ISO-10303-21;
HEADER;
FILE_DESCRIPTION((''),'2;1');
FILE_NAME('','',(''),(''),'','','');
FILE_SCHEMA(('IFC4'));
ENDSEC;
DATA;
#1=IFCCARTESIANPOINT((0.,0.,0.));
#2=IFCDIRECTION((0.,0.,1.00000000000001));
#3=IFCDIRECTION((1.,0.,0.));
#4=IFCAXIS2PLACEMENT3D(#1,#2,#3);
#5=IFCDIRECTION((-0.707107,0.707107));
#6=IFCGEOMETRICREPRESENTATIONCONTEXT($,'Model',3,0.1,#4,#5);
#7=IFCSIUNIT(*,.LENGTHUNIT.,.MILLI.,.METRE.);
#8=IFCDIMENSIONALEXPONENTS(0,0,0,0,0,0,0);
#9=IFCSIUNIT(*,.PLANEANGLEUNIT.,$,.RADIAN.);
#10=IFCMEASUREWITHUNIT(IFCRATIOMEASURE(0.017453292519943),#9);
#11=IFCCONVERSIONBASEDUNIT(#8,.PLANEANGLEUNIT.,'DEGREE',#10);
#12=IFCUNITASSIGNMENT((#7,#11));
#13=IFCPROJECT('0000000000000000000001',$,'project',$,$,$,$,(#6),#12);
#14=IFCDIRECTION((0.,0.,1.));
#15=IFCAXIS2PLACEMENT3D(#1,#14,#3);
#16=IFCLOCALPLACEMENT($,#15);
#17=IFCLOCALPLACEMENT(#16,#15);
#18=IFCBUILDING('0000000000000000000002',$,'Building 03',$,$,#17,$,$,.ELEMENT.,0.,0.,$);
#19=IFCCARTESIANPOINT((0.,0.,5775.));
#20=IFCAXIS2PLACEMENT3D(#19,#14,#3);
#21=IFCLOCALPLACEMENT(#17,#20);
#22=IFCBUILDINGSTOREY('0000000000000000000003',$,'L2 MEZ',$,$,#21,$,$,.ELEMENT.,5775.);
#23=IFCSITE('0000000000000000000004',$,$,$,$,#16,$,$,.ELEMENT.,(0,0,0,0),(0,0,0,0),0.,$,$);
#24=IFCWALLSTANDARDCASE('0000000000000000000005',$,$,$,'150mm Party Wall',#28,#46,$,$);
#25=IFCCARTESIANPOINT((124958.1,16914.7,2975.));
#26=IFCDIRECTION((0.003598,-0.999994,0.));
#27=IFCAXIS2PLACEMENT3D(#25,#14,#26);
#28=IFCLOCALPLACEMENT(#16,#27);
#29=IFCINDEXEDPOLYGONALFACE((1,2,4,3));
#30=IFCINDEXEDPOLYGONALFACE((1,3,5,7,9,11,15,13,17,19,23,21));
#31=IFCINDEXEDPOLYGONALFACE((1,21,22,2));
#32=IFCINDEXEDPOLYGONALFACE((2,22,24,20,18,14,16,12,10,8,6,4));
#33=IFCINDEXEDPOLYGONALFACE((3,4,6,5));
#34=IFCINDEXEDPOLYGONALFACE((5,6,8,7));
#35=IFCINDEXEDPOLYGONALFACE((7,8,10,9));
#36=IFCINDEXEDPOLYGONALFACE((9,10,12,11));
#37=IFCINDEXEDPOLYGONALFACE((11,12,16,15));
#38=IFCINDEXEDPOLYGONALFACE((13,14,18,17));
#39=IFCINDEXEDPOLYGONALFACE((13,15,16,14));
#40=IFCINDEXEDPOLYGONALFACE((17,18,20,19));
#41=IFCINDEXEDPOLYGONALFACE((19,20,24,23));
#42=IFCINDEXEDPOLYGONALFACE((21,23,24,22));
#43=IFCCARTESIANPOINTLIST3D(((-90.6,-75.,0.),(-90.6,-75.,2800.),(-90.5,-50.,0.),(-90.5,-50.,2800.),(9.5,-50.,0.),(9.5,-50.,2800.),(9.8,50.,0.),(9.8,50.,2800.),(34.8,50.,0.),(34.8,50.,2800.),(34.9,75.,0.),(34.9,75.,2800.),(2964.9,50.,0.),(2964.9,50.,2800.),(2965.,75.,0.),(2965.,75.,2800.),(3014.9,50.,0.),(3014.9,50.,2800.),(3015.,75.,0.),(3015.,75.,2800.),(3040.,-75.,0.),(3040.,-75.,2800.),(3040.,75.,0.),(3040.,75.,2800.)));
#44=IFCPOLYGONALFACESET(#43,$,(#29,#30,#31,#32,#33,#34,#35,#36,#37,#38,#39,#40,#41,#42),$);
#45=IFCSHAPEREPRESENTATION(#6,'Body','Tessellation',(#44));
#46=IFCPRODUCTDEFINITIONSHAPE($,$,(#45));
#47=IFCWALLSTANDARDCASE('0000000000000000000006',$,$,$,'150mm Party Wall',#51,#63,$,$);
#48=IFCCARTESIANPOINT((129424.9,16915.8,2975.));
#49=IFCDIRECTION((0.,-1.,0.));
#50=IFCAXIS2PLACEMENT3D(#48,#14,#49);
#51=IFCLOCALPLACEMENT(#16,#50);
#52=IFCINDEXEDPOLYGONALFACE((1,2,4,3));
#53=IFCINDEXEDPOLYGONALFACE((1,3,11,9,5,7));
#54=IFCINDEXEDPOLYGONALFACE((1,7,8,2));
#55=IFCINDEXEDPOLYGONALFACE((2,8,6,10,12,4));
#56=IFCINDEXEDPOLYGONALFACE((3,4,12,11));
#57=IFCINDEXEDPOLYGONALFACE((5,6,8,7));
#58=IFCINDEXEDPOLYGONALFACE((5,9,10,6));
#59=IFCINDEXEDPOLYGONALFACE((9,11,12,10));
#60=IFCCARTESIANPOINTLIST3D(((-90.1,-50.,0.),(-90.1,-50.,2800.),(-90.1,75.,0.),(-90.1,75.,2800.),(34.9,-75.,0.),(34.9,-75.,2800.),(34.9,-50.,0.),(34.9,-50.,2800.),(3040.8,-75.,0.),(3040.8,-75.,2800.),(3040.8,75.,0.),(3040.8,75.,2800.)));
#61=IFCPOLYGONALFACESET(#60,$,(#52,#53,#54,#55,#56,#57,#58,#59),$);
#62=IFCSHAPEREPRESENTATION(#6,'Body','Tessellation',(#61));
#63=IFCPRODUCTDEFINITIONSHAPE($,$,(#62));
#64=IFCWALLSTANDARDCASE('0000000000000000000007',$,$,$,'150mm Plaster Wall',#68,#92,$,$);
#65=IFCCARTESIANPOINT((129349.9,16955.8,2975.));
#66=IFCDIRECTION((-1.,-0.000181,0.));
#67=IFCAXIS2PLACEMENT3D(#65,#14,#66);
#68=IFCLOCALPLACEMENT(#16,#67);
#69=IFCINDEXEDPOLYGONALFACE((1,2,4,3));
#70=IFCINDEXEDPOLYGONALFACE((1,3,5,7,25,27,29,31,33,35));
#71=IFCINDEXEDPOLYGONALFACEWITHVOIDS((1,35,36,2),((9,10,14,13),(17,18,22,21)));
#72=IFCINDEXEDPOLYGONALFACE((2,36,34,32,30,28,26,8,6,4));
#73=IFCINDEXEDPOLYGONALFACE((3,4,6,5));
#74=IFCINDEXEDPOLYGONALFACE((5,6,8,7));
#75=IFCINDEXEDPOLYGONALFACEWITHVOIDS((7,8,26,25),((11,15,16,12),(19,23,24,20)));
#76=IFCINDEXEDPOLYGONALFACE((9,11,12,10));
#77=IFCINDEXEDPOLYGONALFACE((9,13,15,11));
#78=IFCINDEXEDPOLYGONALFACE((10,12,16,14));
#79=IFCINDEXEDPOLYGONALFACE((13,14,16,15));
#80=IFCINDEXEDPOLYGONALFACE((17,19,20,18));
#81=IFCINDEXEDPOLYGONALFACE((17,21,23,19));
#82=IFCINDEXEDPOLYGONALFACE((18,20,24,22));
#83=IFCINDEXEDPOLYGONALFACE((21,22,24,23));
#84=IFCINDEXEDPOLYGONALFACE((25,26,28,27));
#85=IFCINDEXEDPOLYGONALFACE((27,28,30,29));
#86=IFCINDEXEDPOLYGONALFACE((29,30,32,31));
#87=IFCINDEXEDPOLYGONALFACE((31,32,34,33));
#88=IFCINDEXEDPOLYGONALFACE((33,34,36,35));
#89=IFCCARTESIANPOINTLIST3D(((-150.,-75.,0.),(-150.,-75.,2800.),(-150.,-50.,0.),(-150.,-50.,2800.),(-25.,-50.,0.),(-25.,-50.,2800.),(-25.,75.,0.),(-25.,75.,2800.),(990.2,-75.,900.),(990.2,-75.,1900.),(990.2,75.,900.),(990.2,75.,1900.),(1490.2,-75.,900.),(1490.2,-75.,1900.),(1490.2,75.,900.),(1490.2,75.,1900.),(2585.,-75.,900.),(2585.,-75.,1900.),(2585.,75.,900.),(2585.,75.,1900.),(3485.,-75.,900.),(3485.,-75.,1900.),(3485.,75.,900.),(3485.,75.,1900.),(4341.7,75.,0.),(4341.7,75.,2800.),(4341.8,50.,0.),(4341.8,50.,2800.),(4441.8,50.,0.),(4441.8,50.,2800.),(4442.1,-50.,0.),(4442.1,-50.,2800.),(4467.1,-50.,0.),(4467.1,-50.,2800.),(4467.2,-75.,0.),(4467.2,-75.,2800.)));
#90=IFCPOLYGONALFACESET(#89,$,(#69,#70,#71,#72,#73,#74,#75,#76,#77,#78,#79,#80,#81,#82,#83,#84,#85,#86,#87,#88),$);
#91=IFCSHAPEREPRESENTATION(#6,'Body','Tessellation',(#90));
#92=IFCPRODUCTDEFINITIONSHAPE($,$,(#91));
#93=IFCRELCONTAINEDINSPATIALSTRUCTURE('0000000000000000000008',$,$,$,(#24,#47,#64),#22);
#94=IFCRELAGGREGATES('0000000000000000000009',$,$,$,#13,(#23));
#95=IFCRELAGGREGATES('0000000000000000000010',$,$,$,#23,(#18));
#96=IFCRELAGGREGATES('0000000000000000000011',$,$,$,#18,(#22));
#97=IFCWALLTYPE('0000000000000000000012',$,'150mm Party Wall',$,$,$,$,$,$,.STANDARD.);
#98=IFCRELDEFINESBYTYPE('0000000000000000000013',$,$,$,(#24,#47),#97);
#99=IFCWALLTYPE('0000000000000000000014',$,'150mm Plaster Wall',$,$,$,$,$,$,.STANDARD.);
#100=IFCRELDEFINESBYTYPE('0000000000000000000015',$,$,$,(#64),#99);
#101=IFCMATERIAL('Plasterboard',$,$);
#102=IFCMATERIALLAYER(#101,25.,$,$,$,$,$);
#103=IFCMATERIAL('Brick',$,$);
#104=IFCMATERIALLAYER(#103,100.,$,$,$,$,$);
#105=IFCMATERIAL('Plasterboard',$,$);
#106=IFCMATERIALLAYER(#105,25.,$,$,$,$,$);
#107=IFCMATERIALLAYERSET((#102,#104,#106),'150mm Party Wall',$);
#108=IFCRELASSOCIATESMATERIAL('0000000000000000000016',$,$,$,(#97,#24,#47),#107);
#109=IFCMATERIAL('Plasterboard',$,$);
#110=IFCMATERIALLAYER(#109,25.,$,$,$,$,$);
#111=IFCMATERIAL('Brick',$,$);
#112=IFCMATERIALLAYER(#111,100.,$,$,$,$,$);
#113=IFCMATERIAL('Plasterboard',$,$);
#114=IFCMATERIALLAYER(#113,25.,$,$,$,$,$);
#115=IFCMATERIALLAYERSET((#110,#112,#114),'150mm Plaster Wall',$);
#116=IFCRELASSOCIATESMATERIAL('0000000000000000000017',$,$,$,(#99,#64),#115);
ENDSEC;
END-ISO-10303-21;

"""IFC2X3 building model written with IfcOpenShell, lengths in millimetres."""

from ifc_helpers import new_model, entity, si_unit, converted_unit, direction, frame, origin_with_axes, origin_2d, place, context, project, spatial, polyline, rectangle, outline, extrude, material, layer, layer_set, layer_usage, type_object, element, save


model = new_model("IFC2X3")

# Units and contexts
model_context = context("Model", 3, precision=0.1, world=frame((0.0, 0.0, 0.0), z_axis=(0.0, 0.0, 1.00000000000001), x_axis=(1.0, 0.0, 0.0)), true_north=direction((-0.707107, 0.707107)))
ifc_project = project(units=[si_unit("LENGTHUNIT", "METRE", prefix="MILLI"), converted_unit("PLANEANGLEUNIT", "DEGREE", entity("IfcRatioMeasure", 0.017453292519943), si_unit("PLANEANGLEUNIT", "RADIAN"), dimensions=[0, 0, 0, 0, 0, 0, 0])], contexts=[model_context])

# Site, building, storey
site_placement = place(None, origin_with_axes())
site = spatial("IfcSite", under=ifc_project, at=site_placement, CompositionType="ELEMENT", RefLatitude=(0, 0, 0, 0), RefLongitude=(0, 0, 0, 0), RefElevation=0.0)
building_placement = place(site_placement, origin_with_axes())
building = spatial("IfcBuilding", under=site, at=building_placement, Name="Building 03", CompositionType="ELEMENT", ElevationOfRefHeight=0.0, ElevationOfTerrain=0.0)
storey_placement = place(building_placement, frame((0.0, 0.0, 5775.0), z_axis=(0.0, 0.0, 1.0), x_axis=(1.0, 0.0, 0.0)))
storey = spatial("IfcBuildingStorey", under=building, at=storey_placement, Name="L2 MEZ", CompositionType="ELEMENT", Elevation=5775.0)

# Walls
ifc_material_1 = material(Name="Plasterboard")
ifc_layer_1 = layer(ifc_material_1, 25.0)
ifc_material_2 = material(Name="Brick")
ifc_layer_2 = layer(ifc_material_2, 100.0)
ifc_material_3 = material(Name="Plasterboard")
ifc_layer_3 = layer(ifc_material_3, 25.0)
ifc_layer_set_1 = layer_set([ifc_layer_1, ifc_layer_2, ifc_layer_3], Name="150mm Party Wall")
ifc_layer_usage_1 = layer_usage(ifc_layer_set_1, "AXIS2", "POSITIVE", -75.0)
wall_type_1 = type_object("IfcWallType", Name="150mm Party Wall", PredefinedType="STANDARD", material=ifc_layer_set_1)
wall_1_placement = place(site_placement, frame((124958.1, 16914.7, 2975.0), z_axis=(0.0, 0.0, 1.0), x_axis=(0.003598, -0.999994, 0.0)))
element("IfcWallStandardCase", 1, at=wall_1_placement, inside=storey, type_object=wall_type_1, material=ifc_layer_usage_1, ObjectType="150mm Party Wall", context=model_context, shape_type="SweptSolid", body=[
    extrude(outline(polyline([(3014.9, 50.0), (3015.0, 75.0), (3040.0, 75.0), (3040.0, -75.0), (-90.6, -75.0), (-90.5, -50.0), (9.5, -50.0), (9.8, 50.0), (34.8, 50.0), (34.9, 75.0), (2965.0, 75.0), (2964.9, 50.0), (3014.9, 50.0)])), origin_with_axes(), (0.0, 0.0, 1.0), 2800.0),
])
wall_2_placement = place(site_placement, frame((129424.9, 16915.8, 2975.0), z_axis=(0.0, 0.0, 1.0), x_axis=(0.0, -1.0, 0.0)))
element("IfcWallStandardCase", 2, at=wall_2_placement, inside=storey, type_object=wall_type_1, material=ifc_layer_usage_1, ObjectType="150mm Party Wall", context=model_context, shape_type="SweptSolid", body=[
    extrude(outline(polyline([(-90.1, 75.0), (3040.8, 75.0), (3040.8, -75.0), (34.9, -75.0), (34.9, -50.0), (-90.1, -50.0), (-90.1, 75.0)])), origin_with_axes(), (0.0, 0.0, 1.0), 2800.0),
])

# Shared definitions
ifc_material_4 = material(Name="Plasterboard")
ifc_layer_4 = layer(ifc_material_4, 25.0)
ifc_material_5 = material(Name="Brick")
ifc_layer_5 = layer(ifc_material_5, 100.0)
ifc_material_6 = material(Name="Plasterboard")
ifc_layer_6 = layer(ifc_material_6, 25.0)
ifc_layer_set_2 = layer_set([ifc_layer_4, ifc_layer_5, ifc_layer_6], Name="150mm Plaster Wall")
ifc_layer_usage_2 = layer_usage(ifc_layer_set_2, "AXIS2", "POSITIVE", -75.0)
wall_type_2 = type_object("IfcWallType", Name="150mm Plaster Wall", PredefinedType="STANDARD", material=ifc_layer_set_2)

# Wall, openings
wall_3_placement = place(site_placement, frame((129349.9, 16955.8, 2975.0), z_axis=(0.0, 0.0, 1.0), x_axis=(-1.0, -0.000181, 0.0)))
wall_3 = element("IfcWallStandardCase", 3, at=wall_3_placement, inside=storey, type_object=wall_type_2, material=ifc_layer_usage_2, ObjectType="150mm Plaster Wall", context=model_context, shape_type="SweptSolid", body=[
    extrude(outline(polyline([(4341.7, 75.0), (4341.8, 50.0), (4441.8, 50.0), (4442.1, -50.0), (4467.1, -50.0), (4467.2, -75.0), (-150.0, -75.0), (-150.0, -50.0), (-25.0, -50.0), (-25.0, 75.0), (4341.7, 75.0)])), origin_with_axes(), (0.0, 0.0, 1.0), 2800.0),
])
opening_1_placement = place(wall_3_placement, frame((1240.2, 45.0, 900.0), z_axis=(0.0, 0.0, 1.0), x_axis=(1.0, 0.0, 0.0)))
element("IfcOpeningElement", 4, at=opening_1_placement, cuts=wall_3, ObjectType="Opening", context=model_context, shape_type="SweptSolid", body=[
    extrude(rectangle(XDim=500.0, YDim=1000.0, at=origin_2d()), frame((0.0, 450.0, 500.0), z_axis=(0.0, -1.0, 0.0), x_axis=(1.0, 0.0, 0.0)), (0.0, 0.0, 1.0), 900.0),
])
opening_2_placement = place(wall_3_placement, frame((3035.0, 0.0, 900.0), z_axis=(0.0, 0.0, 1.0), x_axis=(1.0, 0.0, 0.0)))
element("IfcOpeningElement", 5, at=opening_2_placement, cuts=wall_3, ObjectType="Opening", context=model_context, shape_type="SweptSolid", body=[
    extrude(rectangle(XDim=900.0, YDim=1000.0, at=origin_2d()), frame((0.0, 850.0, 500.0), z_axis=(0.0, -1.0, 0.0), x_axis=(1.0, 0.0, 0.0)), (0.0, 0.0, 1.0), 1700.0),
])

save(model, "model.ifc")
